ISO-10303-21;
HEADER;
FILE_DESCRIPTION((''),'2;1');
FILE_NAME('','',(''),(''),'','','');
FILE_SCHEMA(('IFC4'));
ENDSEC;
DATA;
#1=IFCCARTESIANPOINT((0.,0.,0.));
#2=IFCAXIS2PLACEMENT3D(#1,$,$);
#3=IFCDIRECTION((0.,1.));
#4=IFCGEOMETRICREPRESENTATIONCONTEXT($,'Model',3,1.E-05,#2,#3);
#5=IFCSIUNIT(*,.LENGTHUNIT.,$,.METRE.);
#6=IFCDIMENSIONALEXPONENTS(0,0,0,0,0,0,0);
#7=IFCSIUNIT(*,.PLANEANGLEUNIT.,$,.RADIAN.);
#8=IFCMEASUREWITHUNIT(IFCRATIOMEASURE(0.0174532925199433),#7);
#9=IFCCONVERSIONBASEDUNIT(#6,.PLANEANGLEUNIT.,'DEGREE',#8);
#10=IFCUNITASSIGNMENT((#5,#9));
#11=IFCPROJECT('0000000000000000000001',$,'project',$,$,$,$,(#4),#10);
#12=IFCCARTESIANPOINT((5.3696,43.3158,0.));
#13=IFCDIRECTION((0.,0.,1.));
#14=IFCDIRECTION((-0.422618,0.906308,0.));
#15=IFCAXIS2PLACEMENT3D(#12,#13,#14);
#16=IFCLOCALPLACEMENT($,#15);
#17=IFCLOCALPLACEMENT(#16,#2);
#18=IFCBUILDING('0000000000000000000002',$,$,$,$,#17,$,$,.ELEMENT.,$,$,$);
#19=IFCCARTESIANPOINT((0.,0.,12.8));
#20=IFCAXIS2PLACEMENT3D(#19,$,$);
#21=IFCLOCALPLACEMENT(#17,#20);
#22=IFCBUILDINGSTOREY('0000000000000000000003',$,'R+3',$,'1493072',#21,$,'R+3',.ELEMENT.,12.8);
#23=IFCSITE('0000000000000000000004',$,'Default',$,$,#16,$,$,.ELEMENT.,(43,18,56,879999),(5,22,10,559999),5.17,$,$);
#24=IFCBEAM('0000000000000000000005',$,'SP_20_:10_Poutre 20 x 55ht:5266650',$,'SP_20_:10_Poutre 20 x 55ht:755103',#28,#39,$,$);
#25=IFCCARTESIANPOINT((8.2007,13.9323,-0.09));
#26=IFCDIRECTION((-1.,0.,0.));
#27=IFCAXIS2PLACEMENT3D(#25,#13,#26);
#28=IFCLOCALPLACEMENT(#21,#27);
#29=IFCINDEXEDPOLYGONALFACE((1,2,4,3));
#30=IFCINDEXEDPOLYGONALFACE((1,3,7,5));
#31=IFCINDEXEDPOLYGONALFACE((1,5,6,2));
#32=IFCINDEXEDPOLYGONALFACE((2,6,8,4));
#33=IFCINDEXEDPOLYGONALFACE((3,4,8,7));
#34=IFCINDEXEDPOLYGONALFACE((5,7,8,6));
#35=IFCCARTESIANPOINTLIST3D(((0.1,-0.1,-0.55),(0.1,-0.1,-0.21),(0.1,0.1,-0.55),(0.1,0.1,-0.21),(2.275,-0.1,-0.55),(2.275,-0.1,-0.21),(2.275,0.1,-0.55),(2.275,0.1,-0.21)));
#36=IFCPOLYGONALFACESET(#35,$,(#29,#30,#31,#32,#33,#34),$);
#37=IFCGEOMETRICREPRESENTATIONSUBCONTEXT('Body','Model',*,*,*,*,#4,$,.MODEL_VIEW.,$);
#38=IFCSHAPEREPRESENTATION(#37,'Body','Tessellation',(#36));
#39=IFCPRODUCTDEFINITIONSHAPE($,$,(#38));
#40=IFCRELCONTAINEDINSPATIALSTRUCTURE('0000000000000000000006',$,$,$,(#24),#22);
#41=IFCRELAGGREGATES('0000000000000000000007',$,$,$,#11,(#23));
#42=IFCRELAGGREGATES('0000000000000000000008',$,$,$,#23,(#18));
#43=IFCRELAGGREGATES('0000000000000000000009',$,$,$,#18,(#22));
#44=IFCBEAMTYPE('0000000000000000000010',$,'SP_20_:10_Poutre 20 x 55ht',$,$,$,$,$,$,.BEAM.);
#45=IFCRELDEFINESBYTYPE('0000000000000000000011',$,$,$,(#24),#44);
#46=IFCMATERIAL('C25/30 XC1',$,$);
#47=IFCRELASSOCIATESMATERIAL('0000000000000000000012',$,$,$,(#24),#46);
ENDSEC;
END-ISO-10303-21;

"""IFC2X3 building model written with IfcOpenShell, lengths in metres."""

from ifc_helpers import new_model, entity, si_unit, converted_unit, direction, frame, frame_2d, origin, place, context, subcontext, project, spatial, rectangle, extrude, material, type_object, element, save


model = new_model("IFC2X3")

# Units and contexts
model_context = context("Model", 3, precision=1e-05, world=origin(), true_north=direction((0.0, 1.0)))
body_context = subcontext(model_context, "Body", "Model", "MODEL_VIEW")
ifc_project = project(units=[si_unit("LENGTHUNIT", "METRE"), converted_unit("PLANEANGLEUNIT", "DEGREE", entity("IfcRatioMeasure", 0.0174532925199433), si_unit("PLANEANGLEUNIT", "RADIAN"), dimensions=[0, 0, 0, 0, 0, 0, 0])], contexts=[model_context])

# Site, building, storey
site_placement = place(None, frame((5.3696, 43.3158, 0.0), z_axis=(0.0, 0.0, 1.0), x_axis=(-0.422618, 0.906308, 0.0)))
site = spatial("IfcSite", under=ifc_project, at=site_placement, Name="Default", CompositionType="ELEMENT", RefLatitude=(43, 18, 56, 879999), RefLongitude=(5, 22, 10, 559999), RefElevation=5.17)
building_placement = place(site_placement, origin())
building = spatial("IfcBuilding", under=site, at=building_placement, CompositionType="ELEMENT")
storey_placement = place(building_placement, frame((0.0, 0.0, 12.8)))
storey = spatial("IfcBuildingStorey", under=building, at=storey_placement, Name="R+3", ObjectType="1493072", LongName="R+3", CompositionType="ELEMENT", Elevation=12.8)

# Beam
ifc_material_1 = material(Name="C25/30 XC1")
beam_type_1 = type_object("IfcBeamType", Name="SP_20_:10_Poutre 20 x 55ht", PredefinedType="BEAM")
beam_1_placement = place(storey_placement, frame((8.2007, 13.9323, -0.09), z_axis=(0.0, 0.0, 1.0), x_axis=(-1.0, 0.0, 0.0)))
element("IfcBeam", 1, at=beam_1_placement, inside=storey, type_object=beam_type_1, material=ifc_material_1, Name="SP_20_:10_Poutre 20 x 55ht:5266650", ObjectType="SP_20_:10_Poutre 20 x 55ht:755103", context=body_context, shape_type="SweptSolid", body=[
    extrude(rectangle(XDim=0.34, YDim=0.2, at=frame_2d((0.0, 0.0), x_axis=(1.0, 0.0))), frame((0.1, 0.0, -0.38), z_axis=(1.0, 0.0, 0.0), x_axis=(0.0, 0.0, -1.0)), (0.0, 0.0, 1.0), 2.175),
])

save(model, "model.ifc")
